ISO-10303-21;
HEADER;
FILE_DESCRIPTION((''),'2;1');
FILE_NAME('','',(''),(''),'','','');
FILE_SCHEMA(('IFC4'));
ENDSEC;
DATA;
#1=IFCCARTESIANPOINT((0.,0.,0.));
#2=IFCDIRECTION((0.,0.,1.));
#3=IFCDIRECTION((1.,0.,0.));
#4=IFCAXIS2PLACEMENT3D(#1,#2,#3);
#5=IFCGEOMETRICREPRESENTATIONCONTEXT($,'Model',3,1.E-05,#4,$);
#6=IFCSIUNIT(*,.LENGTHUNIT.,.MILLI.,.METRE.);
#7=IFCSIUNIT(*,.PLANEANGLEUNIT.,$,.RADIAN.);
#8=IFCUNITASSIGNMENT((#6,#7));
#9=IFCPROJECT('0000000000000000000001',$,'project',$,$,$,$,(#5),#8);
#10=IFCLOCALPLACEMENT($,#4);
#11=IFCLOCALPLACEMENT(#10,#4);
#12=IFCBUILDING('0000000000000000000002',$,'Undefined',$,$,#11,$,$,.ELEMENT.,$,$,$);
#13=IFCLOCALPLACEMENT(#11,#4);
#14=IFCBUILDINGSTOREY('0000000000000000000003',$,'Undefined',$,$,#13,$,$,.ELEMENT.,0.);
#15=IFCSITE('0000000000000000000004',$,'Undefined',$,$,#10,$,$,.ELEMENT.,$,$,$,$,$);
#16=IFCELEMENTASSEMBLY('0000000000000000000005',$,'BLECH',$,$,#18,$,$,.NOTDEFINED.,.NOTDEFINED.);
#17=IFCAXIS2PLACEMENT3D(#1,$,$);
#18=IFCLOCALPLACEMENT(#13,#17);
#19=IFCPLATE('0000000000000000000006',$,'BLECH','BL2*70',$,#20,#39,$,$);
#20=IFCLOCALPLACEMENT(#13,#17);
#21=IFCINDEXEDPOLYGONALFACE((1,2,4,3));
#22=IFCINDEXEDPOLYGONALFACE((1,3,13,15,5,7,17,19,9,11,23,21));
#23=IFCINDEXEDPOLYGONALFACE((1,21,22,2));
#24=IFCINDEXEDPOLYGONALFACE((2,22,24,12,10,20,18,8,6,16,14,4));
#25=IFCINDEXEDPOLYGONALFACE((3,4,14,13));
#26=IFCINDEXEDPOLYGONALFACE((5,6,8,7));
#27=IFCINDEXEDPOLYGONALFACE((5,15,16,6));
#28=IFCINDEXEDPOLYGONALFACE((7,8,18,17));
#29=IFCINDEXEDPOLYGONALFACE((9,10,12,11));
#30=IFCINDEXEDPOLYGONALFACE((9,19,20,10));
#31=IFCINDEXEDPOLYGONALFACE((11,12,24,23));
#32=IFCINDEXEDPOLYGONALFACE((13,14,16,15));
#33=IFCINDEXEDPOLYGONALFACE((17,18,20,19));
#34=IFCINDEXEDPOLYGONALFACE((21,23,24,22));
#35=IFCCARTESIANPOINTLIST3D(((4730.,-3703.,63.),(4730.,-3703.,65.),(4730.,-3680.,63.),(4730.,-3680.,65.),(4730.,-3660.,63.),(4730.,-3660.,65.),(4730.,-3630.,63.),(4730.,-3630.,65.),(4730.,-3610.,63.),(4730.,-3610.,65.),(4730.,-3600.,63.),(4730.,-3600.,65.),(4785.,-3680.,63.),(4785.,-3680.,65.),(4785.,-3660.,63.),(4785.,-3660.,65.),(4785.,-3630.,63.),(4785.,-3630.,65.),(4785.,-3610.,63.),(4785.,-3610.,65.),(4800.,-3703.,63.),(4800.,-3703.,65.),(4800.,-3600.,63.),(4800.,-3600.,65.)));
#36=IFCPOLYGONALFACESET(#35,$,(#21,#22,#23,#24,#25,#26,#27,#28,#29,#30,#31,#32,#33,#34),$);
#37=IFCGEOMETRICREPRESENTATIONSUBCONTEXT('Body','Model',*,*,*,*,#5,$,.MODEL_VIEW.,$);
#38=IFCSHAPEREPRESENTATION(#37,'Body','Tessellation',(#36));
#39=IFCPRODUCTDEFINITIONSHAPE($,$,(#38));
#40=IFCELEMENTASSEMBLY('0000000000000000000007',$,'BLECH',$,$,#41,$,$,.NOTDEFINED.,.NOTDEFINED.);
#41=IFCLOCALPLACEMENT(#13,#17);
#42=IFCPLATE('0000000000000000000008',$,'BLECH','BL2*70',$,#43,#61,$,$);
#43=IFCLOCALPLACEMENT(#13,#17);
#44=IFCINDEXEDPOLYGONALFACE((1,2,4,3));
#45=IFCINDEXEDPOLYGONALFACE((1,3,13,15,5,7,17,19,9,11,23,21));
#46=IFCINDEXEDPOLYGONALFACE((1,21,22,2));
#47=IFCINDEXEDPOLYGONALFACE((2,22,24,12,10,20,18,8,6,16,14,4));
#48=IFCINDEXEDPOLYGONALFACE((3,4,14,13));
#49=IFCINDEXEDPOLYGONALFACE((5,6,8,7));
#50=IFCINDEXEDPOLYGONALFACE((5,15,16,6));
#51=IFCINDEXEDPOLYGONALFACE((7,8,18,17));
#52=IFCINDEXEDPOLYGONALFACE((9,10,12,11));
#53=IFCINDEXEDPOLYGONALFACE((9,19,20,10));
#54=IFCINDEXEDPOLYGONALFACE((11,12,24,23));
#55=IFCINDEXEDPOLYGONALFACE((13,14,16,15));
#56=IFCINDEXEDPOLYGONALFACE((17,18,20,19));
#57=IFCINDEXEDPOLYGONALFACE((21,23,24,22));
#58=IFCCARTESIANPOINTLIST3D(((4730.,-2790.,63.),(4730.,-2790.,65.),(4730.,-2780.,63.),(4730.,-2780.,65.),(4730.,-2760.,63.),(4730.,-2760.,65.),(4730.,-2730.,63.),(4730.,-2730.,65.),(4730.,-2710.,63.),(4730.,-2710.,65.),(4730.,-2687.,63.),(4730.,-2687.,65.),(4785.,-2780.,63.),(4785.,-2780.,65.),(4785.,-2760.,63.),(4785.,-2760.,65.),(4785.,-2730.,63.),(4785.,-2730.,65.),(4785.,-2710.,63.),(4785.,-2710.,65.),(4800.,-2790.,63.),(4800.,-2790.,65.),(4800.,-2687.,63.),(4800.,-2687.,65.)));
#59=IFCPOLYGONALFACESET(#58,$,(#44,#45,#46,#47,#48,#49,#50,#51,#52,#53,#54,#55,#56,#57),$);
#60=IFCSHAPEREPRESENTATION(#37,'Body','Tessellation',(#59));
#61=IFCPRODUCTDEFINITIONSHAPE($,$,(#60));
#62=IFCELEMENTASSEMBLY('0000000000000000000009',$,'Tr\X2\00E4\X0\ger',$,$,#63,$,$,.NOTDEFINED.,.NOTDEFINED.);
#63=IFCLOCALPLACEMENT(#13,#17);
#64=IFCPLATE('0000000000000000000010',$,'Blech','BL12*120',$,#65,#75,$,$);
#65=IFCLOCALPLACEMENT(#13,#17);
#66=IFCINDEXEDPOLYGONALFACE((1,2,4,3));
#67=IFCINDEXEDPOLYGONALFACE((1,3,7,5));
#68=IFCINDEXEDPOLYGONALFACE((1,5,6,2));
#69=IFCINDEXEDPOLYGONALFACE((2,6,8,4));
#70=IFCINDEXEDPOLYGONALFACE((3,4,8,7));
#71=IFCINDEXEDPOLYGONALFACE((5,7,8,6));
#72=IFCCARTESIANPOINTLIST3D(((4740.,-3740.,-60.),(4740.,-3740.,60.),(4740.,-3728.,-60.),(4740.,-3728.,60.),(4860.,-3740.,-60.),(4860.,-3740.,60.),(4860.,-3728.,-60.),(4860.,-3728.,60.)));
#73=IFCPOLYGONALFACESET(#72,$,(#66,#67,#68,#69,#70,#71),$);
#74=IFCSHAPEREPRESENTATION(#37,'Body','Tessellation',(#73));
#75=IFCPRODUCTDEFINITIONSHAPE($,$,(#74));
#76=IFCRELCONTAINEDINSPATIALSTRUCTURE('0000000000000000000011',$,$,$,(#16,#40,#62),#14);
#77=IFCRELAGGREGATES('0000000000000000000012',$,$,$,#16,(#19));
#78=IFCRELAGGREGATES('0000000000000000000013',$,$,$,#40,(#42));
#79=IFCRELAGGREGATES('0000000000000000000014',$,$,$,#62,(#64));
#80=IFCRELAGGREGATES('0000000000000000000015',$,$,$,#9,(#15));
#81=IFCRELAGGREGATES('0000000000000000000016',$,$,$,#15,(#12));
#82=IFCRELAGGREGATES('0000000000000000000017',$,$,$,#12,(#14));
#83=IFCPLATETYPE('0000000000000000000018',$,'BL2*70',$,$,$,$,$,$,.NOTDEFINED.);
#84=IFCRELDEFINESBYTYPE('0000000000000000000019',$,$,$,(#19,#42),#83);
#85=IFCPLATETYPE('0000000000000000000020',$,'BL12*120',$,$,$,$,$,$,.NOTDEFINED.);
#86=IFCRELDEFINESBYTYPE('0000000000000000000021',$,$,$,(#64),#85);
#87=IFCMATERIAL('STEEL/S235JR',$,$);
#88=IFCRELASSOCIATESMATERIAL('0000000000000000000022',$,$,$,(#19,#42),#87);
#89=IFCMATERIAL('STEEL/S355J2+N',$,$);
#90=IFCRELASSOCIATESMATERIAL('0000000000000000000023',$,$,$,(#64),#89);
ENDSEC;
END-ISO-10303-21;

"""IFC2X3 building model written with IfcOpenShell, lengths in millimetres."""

from ifc_helpers import new_model, si_unit, frame, origin_with_axes, place, context, subcontext, project, spatial, polyline, outline, extrude, material, type_object, element, aggregate, save


model = new_model("IFC2X3")

# Units and contexts
model_context = context("Model", 3, precision=1e-05, world=origin_with_axes())
body_context = subcontext(model_context, "Body", "Model", "MODEL_VIEW")
ifc_project = project(units=[si_unit("LENGTHUNIT", "METRE", prefix="MILLI"), si_unit("PLANEANGLEUNIT", "RADIAN")], contexts=[model_context])

# Site, building, storey
site_placement = place(None, origin_with_axes())
site = spatial("IfcSite", under=ifc_project, at=site_placement, Name="Undefined", CompositionType="ELEMENT")
building_placement = place(site_placement, origin_with_axes())
building = spatial("IfcBuilding", under=site, at=building_placement, Name="Undefined", CompositionType="ELEMENT")
storey_placement = place(building_placement, origin_with_axes())
storey = spatial("IfcBuildingStorey", under=building, at=storey_placement, Name="Undefined", CompositionType="ELEMENT", Elevation=0.0)

# Shared definitions
ifc_material_1 = material(Name="STEEL/S235JR")

# Element assemblies, plates
assembly_1_placement = place(storey_placement, origin_with_axes())
assembly_1 = element("IfcElementAssembly", 1, at=assembly_1_placement, inside=storey, Name="BLECH", AssemblyPlace="NOTDEFINED", PredefinedType="NOTDEFINED")
plate_type_1 = type_object("IfcPlateType", Name="BL2*70", PredefinedType="NOTDEFINED")
plate_1_placement = place(assembly_1_placement, frame((4730.0, -3600.0, 64.0), z_axis=(0.0, 0.0, -1.0), x_axis=(1.0, 0.0, 0.0)))
plate_1 = element("IfcPlate", 2, at=plate_1_placement, type_object=plate_type_1, material=ifc_material_1, Name="BLECH", Description="BL2*70", context=body_context, shape_type="SweptSolid", body=[
    extrude(outline(polyline([(0.0, 0.0), (70.0, 0.0), (70.0, 103.0), (0.0, 103.0), (0.0, 80.0), (55.0, 80.0), (55.0, 60.0), (0.0, 60.0), (0.0, 30.0), (55.0, 30.0), (55.0, 10.0), (0.0, 10.0), (0.0, 0.0)])), frame((0.0, 0.0, -1.0), z_axis=(0.0, 0.0, 1.0), x_axis=(1.0, 0.0, 0.0)), (0.0, 0.0, 1.0), 2.0),
])
aggregate(assembly_1, [plate_1])
assembly_2_placement = place(storey_placement, origin_with_axes())
assembly_2 = element("IfcElementAssembly", 3, at=assembly_2_placement, inside=storey, Name="BLECH", AssemblyPlace="NOTDEFINED", PredefinedType="NOTDEFINED")
plate_2_placement = place(assembly_2_placement, frame((4730.0, -2790.0, 64.0), z_axis=(0.0, 0.0, 1.0), x_axis=(1.0, 0.000009, 0.0)))
plate_2 = element("IfcPlate", 4, at=plate_2_placement, type_object=plate_type_1, material=ifc_material_1, Name="BLECH", Description="BL2*70", context=body_context, shape_type="SweptSolid", body=[
    extrude(outline(polyline([(0.0, 0.0), (70.0, 0.0), (70.0, 103.0), (0.0, 103.0), (0.0, 80.0), (55.0, 80.0), (55.0, 60.0), (0.0, 60.0), (0.0, 30.0), (55.0, 30.0), (55.0, 10.0), (0.0, 10.0), (0.0, 0.0)])), frame((0.0, 0.0, -1.0), z_axis=(0.0, 0.0, 1.0), x_axis=(1.0, 0.0, 0.0)), (0.0, 0.0, 1.0), 2.0),
])
aggregate(assembly_2, [plate_2])
assembly_3_placement = place(storey_placement, origin_with_axes())
assembly_3 = element("IfcElementAssembly", 5, at=assembly_3_placement, inside=storey, Name="Träger", AssemblyPlace="NOTDEFINED", PredefinedType="NOTDEFINED")
ifc_material_2 = material(Name="STEEL/S355J2+N")
plate_type_2 = type_object("IfcPlateType", Name="BL12*120", PredefinedType="NOTDEFINED")
plate_3_placement = place(assembly_3_placement, frame((4800.0, -3734.0, -60.0), z_axis=(0.0, 1.0, 0.0), x_axis=(0.0, 0.0, 1.0)))
plate_3 = element("IfcPlate", 6, at=plate_3_placement, type_object=plate_type_2, material=ifc_material_2, Name="Blech", Description="BL12*120", context=body_context, shape_type="SweptSolid", body=[
    extrude(outline(polyline([(0.0, -60.0), (0.0, 60.0), (120.0, 60.0), (120.0, -60.0), (0.0, -60.0)])), frame((0.0, 0.0, -6.0), z_axis=(0.0, 0.0, 1.0), x_axis=(1.0, 0.0, 0.0)), (0.0, 0.0, 1.0), 12.0),
])
aggregate(assembly_3, [plate_3])

save(model, "model.ifc")
